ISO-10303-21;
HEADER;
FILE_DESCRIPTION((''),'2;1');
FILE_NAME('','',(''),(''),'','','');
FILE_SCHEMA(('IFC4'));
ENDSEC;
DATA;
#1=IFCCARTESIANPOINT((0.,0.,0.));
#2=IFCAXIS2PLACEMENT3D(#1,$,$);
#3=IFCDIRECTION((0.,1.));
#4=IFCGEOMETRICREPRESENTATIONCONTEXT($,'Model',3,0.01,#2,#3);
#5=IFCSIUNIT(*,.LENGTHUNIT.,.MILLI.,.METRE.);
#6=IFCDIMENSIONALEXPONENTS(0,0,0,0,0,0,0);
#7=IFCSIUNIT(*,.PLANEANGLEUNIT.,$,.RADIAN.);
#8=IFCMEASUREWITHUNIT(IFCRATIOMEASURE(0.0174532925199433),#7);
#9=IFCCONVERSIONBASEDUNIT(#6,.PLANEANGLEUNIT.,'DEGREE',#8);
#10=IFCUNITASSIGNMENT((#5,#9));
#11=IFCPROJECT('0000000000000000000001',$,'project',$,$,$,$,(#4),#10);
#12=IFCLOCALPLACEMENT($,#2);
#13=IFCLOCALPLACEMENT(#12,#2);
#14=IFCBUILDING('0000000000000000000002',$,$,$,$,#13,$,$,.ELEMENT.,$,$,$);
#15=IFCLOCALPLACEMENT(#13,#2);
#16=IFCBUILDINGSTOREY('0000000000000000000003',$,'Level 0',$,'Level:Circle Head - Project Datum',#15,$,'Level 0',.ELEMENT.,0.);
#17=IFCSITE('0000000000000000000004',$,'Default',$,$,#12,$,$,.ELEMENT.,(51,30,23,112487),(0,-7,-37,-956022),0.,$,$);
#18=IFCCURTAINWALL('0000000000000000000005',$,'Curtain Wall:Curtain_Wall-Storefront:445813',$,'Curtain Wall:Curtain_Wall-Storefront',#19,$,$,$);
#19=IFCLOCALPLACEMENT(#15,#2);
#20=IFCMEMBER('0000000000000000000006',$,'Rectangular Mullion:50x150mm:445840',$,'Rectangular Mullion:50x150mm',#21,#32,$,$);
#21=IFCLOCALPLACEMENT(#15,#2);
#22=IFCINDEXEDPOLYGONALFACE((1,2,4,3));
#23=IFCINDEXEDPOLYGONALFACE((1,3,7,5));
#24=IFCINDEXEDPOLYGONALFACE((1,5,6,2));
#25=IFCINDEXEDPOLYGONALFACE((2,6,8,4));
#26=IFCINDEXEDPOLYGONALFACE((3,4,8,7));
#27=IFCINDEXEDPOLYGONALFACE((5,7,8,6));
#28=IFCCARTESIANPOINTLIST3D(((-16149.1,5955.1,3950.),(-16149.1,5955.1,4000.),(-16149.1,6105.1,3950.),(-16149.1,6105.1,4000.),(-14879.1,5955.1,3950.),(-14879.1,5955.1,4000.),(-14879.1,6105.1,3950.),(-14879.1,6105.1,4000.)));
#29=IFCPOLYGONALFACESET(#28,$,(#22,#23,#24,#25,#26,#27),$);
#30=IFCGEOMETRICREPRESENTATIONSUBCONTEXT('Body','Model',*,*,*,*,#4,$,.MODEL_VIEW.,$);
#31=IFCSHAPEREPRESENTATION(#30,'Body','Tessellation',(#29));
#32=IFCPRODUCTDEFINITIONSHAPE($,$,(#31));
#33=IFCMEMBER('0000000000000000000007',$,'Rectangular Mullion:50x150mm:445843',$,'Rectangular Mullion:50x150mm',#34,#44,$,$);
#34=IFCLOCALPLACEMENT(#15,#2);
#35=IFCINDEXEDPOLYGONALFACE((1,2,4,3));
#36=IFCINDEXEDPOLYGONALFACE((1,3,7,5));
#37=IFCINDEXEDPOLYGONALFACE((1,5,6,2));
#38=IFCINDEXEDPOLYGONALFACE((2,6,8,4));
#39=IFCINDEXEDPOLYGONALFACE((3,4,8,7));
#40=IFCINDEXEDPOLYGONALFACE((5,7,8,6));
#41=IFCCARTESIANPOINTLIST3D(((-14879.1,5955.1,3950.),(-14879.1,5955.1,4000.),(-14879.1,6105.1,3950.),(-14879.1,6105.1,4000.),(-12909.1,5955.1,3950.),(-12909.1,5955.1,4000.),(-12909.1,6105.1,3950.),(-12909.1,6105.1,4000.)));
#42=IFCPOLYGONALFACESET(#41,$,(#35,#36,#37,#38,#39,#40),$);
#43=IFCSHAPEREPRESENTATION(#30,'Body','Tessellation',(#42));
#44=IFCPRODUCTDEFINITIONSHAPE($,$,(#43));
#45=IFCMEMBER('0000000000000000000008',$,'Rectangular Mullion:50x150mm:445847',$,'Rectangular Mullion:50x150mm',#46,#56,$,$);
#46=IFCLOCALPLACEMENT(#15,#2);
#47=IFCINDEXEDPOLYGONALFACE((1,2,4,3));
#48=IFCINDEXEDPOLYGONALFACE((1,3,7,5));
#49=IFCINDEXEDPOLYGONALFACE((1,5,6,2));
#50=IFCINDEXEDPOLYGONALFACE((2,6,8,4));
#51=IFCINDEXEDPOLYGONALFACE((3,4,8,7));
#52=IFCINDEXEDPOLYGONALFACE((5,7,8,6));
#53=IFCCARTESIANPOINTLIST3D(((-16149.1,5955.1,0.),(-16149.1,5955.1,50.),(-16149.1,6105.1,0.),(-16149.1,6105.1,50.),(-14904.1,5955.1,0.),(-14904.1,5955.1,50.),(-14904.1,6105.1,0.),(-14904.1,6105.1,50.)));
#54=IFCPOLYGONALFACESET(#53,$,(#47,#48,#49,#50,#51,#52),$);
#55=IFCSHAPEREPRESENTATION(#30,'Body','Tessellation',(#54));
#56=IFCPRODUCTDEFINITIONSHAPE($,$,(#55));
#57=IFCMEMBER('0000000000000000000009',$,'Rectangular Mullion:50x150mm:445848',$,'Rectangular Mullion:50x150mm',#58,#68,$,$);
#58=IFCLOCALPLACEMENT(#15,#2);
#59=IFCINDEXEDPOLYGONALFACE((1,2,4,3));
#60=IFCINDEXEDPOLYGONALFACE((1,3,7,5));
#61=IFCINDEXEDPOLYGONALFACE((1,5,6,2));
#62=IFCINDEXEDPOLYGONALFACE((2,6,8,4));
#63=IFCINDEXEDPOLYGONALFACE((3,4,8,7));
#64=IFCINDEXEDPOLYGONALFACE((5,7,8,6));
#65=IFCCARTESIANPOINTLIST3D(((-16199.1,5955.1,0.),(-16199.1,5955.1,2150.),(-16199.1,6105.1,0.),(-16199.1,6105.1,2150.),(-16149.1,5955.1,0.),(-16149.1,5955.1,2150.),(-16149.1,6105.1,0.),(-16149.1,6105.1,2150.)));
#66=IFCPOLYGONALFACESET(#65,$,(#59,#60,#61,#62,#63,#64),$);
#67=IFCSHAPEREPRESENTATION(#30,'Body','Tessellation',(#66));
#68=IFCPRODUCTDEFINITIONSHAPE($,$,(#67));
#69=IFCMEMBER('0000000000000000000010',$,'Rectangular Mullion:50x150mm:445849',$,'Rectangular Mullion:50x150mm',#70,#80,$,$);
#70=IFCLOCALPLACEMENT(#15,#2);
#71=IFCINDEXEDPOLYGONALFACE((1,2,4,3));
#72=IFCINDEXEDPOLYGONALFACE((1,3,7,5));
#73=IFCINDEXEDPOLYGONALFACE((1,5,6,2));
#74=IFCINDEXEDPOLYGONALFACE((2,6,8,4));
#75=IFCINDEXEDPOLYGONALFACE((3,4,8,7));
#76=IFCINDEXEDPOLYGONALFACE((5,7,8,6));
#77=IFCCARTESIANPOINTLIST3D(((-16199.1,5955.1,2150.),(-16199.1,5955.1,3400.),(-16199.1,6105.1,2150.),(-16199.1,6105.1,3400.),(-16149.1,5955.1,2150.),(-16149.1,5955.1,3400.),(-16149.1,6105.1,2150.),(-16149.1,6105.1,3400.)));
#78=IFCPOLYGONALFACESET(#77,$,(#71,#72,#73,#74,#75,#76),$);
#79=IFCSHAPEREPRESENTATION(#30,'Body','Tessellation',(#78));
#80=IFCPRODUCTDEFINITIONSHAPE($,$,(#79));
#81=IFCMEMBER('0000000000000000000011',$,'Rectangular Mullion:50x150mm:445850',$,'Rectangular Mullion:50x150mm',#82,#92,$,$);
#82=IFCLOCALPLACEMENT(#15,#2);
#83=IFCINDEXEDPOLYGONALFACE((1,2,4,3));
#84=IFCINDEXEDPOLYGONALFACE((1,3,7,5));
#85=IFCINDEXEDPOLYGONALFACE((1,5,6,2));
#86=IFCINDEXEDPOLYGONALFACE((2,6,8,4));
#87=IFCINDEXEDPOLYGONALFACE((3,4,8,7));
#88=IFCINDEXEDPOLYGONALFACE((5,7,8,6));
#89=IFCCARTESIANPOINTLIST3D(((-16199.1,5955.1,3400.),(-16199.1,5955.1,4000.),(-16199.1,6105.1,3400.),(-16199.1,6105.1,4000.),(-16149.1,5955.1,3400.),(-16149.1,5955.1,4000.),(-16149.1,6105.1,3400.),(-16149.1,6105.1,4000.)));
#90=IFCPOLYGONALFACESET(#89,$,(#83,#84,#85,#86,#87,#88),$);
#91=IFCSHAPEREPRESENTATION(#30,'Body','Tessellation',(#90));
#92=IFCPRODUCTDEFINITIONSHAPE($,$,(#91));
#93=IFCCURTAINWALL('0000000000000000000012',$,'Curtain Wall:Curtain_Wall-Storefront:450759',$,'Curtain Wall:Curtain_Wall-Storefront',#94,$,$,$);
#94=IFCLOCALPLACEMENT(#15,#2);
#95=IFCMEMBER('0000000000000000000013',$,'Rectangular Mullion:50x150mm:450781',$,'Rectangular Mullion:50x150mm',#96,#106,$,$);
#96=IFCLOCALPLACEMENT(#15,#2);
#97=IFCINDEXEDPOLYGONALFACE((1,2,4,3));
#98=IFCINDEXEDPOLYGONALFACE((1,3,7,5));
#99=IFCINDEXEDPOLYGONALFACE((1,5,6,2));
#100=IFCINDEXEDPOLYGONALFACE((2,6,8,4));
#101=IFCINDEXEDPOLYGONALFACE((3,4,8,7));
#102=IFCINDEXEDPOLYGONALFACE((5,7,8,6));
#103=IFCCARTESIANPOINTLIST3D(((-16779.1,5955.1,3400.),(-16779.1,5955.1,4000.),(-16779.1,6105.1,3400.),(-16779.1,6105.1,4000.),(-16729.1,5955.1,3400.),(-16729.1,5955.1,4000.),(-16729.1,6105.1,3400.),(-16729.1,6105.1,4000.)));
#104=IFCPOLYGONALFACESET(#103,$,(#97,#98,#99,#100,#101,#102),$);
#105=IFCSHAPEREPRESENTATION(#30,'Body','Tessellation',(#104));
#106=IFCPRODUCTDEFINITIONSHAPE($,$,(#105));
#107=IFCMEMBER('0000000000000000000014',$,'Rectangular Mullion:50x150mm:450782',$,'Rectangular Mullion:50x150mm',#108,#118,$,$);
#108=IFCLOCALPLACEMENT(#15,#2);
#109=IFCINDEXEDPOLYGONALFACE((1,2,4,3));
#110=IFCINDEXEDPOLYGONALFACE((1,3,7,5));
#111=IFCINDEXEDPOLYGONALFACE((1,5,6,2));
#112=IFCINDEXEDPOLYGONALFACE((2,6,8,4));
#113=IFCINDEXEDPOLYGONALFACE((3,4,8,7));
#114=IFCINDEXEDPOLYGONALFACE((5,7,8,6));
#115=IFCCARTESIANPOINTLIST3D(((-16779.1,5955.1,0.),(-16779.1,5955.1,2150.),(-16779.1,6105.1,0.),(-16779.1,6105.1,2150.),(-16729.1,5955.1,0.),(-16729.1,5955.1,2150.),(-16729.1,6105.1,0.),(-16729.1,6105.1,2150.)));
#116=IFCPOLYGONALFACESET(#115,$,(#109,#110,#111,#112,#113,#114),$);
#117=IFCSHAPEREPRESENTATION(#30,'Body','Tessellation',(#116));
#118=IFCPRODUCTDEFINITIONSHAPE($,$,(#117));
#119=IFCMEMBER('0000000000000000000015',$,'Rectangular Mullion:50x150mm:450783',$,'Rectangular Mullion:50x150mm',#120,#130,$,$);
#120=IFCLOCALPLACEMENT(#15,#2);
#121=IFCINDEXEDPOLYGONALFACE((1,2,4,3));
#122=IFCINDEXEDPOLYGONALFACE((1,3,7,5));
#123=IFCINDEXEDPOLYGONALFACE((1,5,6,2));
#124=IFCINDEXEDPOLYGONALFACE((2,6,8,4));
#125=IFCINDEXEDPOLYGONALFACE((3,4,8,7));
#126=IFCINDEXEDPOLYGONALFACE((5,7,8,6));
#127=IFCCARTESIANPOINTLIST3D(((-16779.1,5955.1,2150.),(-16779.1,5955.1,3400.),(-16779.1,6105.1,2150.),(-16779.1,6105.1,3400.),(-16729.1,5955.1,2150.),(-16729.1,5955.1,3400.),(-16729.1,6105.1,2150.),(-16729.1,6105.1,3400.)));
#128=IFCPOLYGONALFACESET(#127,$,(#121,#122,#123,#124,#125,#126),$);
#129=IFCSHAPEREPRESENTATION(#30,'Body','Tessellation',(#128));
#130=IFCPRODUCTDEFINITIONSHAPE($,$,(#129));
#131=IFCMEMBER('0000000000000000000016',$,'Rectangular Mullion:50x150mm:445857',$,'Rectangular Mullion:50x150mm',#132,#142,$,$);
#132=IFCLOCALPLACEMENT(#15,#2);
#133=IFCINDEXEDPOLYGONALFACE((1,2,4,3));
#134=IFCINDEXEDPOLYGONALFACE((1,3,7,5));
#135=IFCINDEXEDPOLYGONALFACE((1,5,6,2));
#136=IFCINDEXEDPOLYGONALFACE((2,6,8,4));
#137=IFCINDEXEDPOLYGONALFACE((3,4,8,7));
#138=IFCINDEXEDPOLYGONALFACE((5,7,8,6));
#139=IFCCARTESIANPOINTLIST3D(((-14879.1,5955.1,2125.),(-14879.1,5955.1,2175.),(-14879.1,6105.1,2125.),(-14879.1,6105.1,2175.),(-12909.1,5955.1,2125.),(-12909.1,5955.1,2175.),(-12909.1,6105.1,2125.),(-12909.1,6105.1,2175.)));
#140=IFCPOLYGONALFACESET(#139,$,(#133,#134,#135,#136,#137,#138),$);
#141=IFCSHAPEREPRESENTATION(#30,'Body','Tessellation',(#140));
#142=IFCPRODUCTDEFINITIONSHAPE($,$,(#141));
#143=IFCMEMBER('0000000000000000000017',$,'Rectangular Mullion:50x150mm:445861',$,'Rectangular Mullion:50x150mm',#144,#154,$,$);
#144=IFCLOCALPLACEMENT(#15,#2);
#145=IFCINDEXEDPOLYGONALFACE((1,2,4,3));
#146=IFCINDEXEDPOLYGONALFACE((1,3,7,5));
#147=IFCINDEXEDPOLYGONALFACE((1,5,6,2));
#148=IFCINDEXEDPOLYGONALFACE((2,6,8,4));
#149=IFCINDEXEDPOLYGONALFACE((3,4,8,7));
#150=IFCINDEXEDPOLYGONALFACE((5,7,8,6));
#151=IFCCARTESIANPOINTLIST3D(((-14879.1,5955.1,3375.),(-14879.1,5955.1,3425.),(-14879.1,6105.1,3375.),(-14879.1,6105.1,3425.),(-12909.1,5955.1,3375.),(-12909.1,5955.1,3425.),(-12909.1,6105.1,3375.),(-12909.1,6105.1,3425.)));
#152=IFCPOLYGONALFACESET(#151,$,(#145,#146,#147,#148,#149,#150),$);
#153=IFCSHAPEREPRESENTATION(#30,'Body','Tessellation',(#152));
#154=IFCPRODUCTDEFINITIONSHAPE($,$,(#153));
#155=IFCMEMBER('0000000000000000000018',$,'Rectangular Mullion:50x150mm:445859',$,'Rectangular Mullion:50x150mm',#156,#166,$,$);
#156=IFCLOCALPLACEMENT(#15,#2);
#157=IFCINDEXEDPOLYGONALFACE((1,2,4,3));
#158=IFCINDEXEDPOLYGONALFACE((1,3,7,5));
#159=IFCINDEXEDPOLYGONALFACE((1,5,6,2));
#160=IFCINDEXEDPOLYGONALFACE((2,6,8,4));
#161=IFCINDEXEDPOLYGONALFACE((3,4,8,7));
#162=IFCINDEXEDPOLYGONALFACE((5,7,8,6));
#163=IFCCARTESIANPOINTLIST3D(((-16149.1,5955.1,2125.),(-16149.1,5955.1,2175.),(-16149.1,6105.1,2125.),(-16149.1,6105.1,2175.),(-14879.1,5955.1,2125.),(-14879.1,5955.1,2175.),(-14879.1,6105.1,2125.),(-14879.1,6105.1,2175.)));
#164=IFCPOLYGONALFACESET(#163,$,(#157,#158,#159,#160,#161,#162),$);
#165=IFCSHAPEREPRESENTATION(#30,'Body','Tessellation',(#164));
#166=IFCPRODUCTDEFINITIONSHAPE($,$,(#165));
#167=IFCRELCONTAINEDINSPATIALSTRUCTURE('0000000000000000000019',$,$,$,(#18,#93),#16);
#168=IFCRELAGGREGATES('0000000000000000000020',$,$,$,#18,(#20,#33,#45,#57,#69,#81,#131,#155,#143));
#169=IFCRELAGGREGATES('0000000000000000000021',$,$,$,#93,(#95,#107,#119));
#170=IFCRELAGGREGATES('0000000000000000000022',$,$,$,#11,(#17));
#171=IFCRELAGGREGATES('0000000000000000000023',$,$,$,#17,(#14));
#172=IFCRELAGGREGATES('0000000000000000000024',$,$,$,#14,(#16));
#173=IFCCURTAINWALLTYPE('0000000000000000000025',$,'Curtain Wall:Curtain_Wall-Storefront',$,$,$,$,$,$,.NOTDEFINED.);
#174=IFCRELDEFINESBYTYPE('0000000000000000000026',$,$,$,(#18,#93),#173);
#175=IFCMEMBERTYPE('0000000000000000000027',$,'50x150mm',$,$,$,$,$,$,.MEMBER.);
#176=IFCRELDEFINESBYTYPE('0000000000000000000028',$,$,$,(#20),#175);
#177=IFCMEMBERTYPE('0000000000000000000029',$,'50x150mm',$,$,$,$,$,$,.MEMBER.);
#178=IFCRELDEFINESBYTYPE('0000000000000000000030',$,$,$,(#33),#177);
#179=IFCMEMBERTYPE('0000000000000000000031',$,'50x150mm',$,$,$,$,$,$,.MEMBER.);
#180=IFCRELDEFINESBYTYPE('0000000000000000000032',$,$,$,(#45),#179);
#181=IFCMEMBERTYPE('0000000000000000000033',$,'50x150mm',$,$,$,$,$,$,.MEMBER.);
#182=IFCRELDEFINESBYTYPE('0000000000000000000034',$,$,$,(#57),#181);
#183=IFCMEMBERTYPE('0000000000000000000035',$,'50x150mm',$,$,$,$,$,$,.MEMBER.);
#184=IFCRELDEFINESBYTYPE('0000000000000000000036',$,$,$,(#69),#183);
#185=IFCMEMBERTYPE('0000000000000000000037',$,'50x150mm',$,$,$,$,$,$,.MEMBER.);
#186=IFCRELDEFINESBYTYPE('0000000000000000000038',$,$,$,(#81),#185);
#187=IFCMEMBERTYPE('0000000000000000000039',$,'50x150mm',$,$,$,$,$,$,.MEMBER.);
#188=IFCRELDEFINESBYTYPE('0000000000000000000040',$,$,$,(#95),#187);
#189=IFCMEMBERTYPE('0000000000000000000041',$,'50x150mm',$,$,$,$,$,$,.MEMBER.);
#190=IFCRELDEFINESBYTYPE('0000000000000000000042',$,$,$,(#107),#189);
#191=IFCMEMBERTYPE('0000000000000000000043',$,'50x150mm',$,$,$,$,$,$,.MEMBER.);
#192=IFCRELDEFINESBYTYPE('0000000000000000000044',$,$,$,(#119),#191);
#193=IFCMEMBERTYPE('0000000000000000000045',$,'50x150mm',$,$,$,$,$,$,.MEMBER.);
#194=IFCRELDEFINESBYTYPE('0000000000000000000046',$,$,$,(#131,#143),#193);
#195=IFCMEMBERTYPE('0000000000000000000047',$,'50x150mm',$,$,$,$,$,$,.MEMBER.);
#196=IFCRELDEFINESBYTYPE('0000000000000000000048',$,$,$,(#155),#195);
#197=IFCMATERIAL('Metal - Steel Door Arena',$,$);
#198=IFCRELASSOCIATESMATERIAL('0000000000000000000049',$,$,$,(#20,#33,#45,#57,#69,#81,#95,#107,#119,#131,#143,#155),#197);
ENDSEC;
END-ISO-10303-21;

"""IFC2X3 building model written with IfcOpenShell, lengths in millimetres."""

from ifc_helpers import new_model, entity, si_unit, converted_unit, direction, frame, origin, origin_2d_with_axis, place, context, subcontext, project, spatial, rectangle, extrude, source, transform, mapped, material, type_object, type_shapes, element, aggregate, save


model = new_model("IFC2X3")

# Units and contexts
model_context = context("Model", 3, precision=0.01, world=origin(), true_north=direction((0.0, 1.0)))
body_context = subcontext(model_context, "Body", "Model", "MODEL_VIEW")
ifc_project = project(units=[si_unit("LENGTHUNIT", "METRE", prefix="MILLI"), converted_unit("PLANEANGLEUNIT", "DEGREE", entity("IfcRatioMeasure", 0.0174532925199433), si_unit("PLANEANGLEUNIT", "RADIAN"), dimensions=[0, 0, 0, 0, 0, 0, 0])], contexts=[model_context])

# Site, building, storey
site_placement = place(None, origin())
site = spatial("IfcSite", under=ifc_project, at=site_placement, Name="Default", CompositionType="ELEMENT", RefLatitude=(51, 30, 23, 112487), RefLongitude=(0, -7, -37, -956022), RefElevation=0.0)
building_placement = place(site_placement, origin())
building = spatial("IfcBuilding", under=site, at=building_placement, CompositionType="ELEMENT")
storey_placement = place(building_placement, origin())
storey = spatial("IfcBuildingStorey", under=building, at=storey_placement, Name="Level 0", ObjectType="Level:Circle Head - Project Datum", LongName="Level 0", CompositionType="ELEMENT", Elevation=0.0)

# Curtain walls, members
curtain_wall_type = type_object("IfcCurtainWallType", Name="Curtain Wall:Curtain_Wall-Storefront", PredefinedType="NOTDEFINED")
curtain_wall_1_placement = place(storey_placement, origin())
curtain_wall_1 = element("IfcCurtainWall", 1, at=curtain_wall_1_placement, inside=storey, type_object=curtain_wall_type, Name="Curtain Wall:Curtain_Wall-Storefront:445813", ObjectType="Curtain Wall:Curtain_Wall-Storefront")
ifc_material_1 = material(Name="Metal - Steel Door Arena")
member_type_1 = type_object("IfcMemberType", Name="50x150mm", PredefinedType="MEMBER")
shared_shape_1 = source(origin(), body_context, "Body", "SweptSolid", [
    extrude(rectangle(XDim=150.0, YDim=50.0, at=origin_2d_with_axis()), frame((-25.0, 0.0, -1270.0), z_axis=(0.0, 0.0, 1.0), x_axis=(0.0, -1.0, 0.0)), (0.0, 0.0, 1.0), 1270.0),
])
type_shapes(member_type_1, [shared_shape_1])
member_1_placement = place(storey_placement, frame((-16149.1, 6030.1, 4000.0), z_axis=(-1.0, 0.0, 0.0), x_axis=(0.0, 0.0, 1.0)))
member_1 = element("IfcMember", 2, at=member_1_placement, type_object=member_type_1, material=ifc_material_1, Name="Rectangular Mullion:50x150mm:445840", ObjectType="Rectangular Mullion:50x150mm", context=body_context, shape_type="MappedRepresentation", body=[
    mapped(shared_shape_1, transform((0.0, 0.0, 0.0), scale=1.0)),
])
member_type_2 = type_object("IfcMemberType", Name="50x150mm", PredefinedType="MEMBER")
shared_shape_2 = source(origin(), body_context, "Body", "SweptSolid", [
    extrude(rectangle(XDim=150.0, YDim=50.0, at=origin_2d_with_axis()), frame((-25.0, 0.0, -1970.0), z_axis=(0.0, 0.0, 1.0), x_axis=(0.0, -1.0, 0.0)), (0.0, 0.0, 1.0), 1970.0),
])
type_shapes(member_type_2, [shared_shape_2])
member_2_placement = place(storey_placement, frame((-14879.1, 6030.1, 4000.0), z_axis=(-1.0, 0.0, 0.0), x_axis=(0.0, 0.0, 1.0)))
member_2 = element("IfcMember", 3, at=member_2_placement, type_object=member_type_2, material=ifc_material_1, Name="Rectangular Mullion:50x150mm:445843", ObjectType="Rectangular Mullion:50x150mm", context=body_context, shape_type="MappedRepresentation", body=[
    mapped(shared_shape_2, transform((0.0, 0.0, 0.0), scale=1.0)),
])
member_type_3 = type_object("IfcMemberType", Name="50x150mm", PredefinedType="MEMBER")
shared_shape_3 = source(origin(), body_context, "Body", "SweptSolid", [
    extrude(rectangle(XDim=150.0, YDim=50.0, at=origin_2d_with_axis()), frame((-25.0, 0.0, -1245.0), z_axis=(0.0, 0.0, 1.0), x_axis=(0.0, -1.0, 0.0)), (0.0, 0.0, 1.0), 1245.0),
])
type_shapes(member_type_3, [shared_shape_3])
member_3_placement = place(storey_placement, frame((-14904.1, 6030.1, 0.0), z_axis=(1.0, 0.0, 0.0), x_axis=(0.0, 0.0, -1.0)))
member_3 = element("IfcMember", 4, at=member_3_placement, type_object=member_type_3, material=ifc_material_1, Name="Rectangular Mullion:50x150mm:445847", ObjectType="Rectangular Mullion:50x150mm", context=body_context, shape_type="MappedRepresentation", body=[
    mapped(shared_shape_3, transform((0.0, 0.0, 0.0), scale=1.0)),
])
member_type_4 = type_object("IfcMemberType", Name="50x150mm", PredefinedType="MEMBER")
shared_shape_4 = source(origin(), body_context, "Body", "SweptSolid", [
    extrude(rectangle(XDim=150.0, YDim=50.0, at=origin_2d_with_axis()), frame((-25.0, 0.0, -2150.0), z_axis=(0.0, 0.0, 1.0), x_axis=(0.0, -1.0, 0.0)), (0.0, 0.0, 1.0), 2150.0),
])
type_shapes(member_type_4, [shared_shape_4])
member_4_placement = place(storey_placement, frame((-16199.1, 6030.1, 0.0), z_axis=(0.0, 0.0, -1.0), x_axis=(-1.0, 0.0, 0.0)))
member_4 = element("IfcMember", 5, at=member_4_placement, type_object=member_type_4, material=ifc_material_1, Name="Rectangular Mullion:50x150mm:445848", ObjectType="Rectangular Mullion:50x150mm", context=body_context, shape_type="MappedRepresentation", body=[
    mapped(shared_shape_4, transform((0.0, 0.0, 0.0), scale=1.0)),
])
member_type_5 = type_object("IfcMemberType", Name="50x150mm", PredefinedType="MEMBER")
shared_shape_5 = source(origin(), body_context, "Body", "SweptSolid", [
    extrude(rectangle(XDim=150.0, YDim=50.0, at=origin_2d_with_axis()), frame((-25.0, 0.0, -1250.0), z_axis=(0.0, 0.0, 1.0), x_axis=(0.0, -1.0, 0.0)), (0.0, 0.0, 1.0), 1250.0),
])
type_shapes(member_type_5, [shared_shape_5])
member_5_placement = place(storey_placement, frame((-16199.1, 6030.1, 2150.0), z_axis=(0.0, 0.0, -1.0), x_axis=(-1.0, 0.0, 0.0)))
member_5 = element("IfcMember", 6, at=member_5_placement, type_object=member_type_5, material=ifc_material_1, Name="Rectangular Mullion:50x150mm:445849", ObjectType="Rectangular Mullion:50x150mm", context=body_context, shape_type="MappedRepresentation", body=[
    mapped(shared_shape_5, transform((0.0, 0.0, 0.0), scale=1.0)),
])
member_type_6 = type_object("IfcMemberType", Name="50x150mm", PredefinedType="MEMBER")
shared_shape_6 = source(origin(), body_context, "Body", "SweptSolid", [
    extrude(rectangle(XDim=150.0, YDim=50.0, at=origin_2d_with_axis()), frame((-25.0, 0.0, -600.0), z_axis=(0.0, 0.0, 1.0), x_axis=(0.0, -1.0, 0.0)), (0.0, 0.0, 1.0), 600.0),
])
type_shapes(member_type_6, [shared_shape_6])
member_6_placement = place(storey_placement, frame((-16199.1, 6030.1, 3400.0), z_axis=(0.0, 0.0, -1.0), x_axis=(-1.0, 0.0, 0.0)))
member_6 = element("IfcMember", 7, at=member_6_placement, type_object=member_type_6, material=ifc_material_1, Name="Rectangular Mullion:50x150mm:445850", ObjectType="Rectangular Mullion:50x150mm", context=body_context, shape_type="MappedRepresentation", body=[
    mapped(shared_shape_6, transform((0.0, 0.0, 0.0), scale=1.0)),
])
curtain_wall_2_placement = place(storey_placement, origin())
curtain_wall_2 = element("IfcCurtainWall", 8, at=curtain_wall_2_placement, inside=storey, type_object=curtain_wall_type, Name="Curtain Wall:Curtain_Wall-Storefront:450759", ObjectType="Curtain Wall:Curtain_Wall-Storefront")
member_type_7 = type_object("IfcMemberType", Name="50x150mm", PredefinedType="MEMBER")
shared_shape_7 = source(origin(), body_context, "Body", "SweptSolid", [
    extrude(rectangle(XDim=150.0, YDim=50.0, at=origin_2d_with_axis()), frame((-25.0, 0.0, -600.0), z_axis=(0.0, 0.0, 1.0), x_axis=(0.0, -1.0, 0.0)), (0.0, 0.0, 1.0), 600.0),
])
type_shapes(member_type_7, [shared_shape_7])
member_7_placement = place(storey_placement, frame((-16729.1, 6030.1, 4000.0)))
member_7 = element("IfcMember", 9, at=member_7_placement, type_object=member_type_7, material=ifc_material_1, Name="Rectangular Mullion:50x150mm:450781", ObjectType="Rectangular Mullion:50x150mm", context=body_context, shape_type="MappedRepresentation", body=[
    mapped(shared_shape_7, transform((0.0, 0.0, 0.0), scale=1.0)),
])
member_type_8 = type_object("IfcMemberType", Name="50x150mm", PredefinedType="MEMBER")
shared_shape_8 = source(origin(), body_context, "Body", "SweptSolid", [
    extrude(rectangle(XDim=150.0, YDim=50.0, at=origin_2d_with_axis()), frame((-25.0, 0.0, -2150.0), z_axis=(0.0, 0.0, 1.0), x_axis=(0.0, -1.0, 0.0)), (0.0, 0.0, 1.0), 2150.0),
])
type_shapes(member_type_8, [shared_shape_8])
member_8_placement = place(storey_placement, frame((-16729.1, 6030.1, 2150.0)))
member_8 = element("IfcMember", 10, at=member_8_placement, type_object=member_type_8, material=ifc_material_1, Name="Rectangular Mullion:50x150mm:450782", ObjectType="Rectangular Mullion:50x150mm", context=body_context, shape_type="MappedRepresentation", body=[
    mapped(shared_shape_8, transform((0.0, 0.0, 0.0), scale=1.0)),
])
member_type_9 = type_object("IfcMemberType", Name="50x150mm", PredefinedType="MEMBER")
shared_shape_9 = source(origin(), body_context, "Body", "SweptSolid", [
    extrude(rectangle(XDim=150.0, YDim=50.0, at=origin_2d_with_axis()), frame((-25.0, 0.0, -1250.0), z_axis=(0.0, 0.0, 1.0), x_axis=(0.0, -1.0, 0.0)), (0.0, 0.0, 1.0), 1250.0),
])
type_shapes(member_type_9, [shared_shape_9])
member_9_placement = place(storey_placement, frame((-16729.1, 6030.1, 3400.0)))
member_9 = element("IfcMember", 11, at=member_9_placement, type_object=member_type_9, material=ifc_material_1, Name="Rectangular Mullion:50x150mm:450783", ObjectType="Rectangular Mullion:50x150mm", context=body_context, shape_type="MappedRepresentation", body=[
    mapped(shared_shape_9, transform((0.0, 0.0, 0.0), scale=1.0)),
])

# Members
member_type_10 = type_object("IfcMemberType", Name="50x150mm", PredefinedType="MEMBER")
shared_shape_10 = source(origin(), body_context, "Body", "SweptSolid", [
    extrude(rectangle(XDim=150.0, YDim=50.0, at=origin_2d_with_axis()), frame((0.0, 0.0, -1970.0), z_axis=(0.0, 0.0, 1.0), x_axis=(0.0, -1.0, 0.0)), (0.0, 0.0, 1.0), 1970.0),
])
type_shapes(member_type_10, [shared_shape_10])
member_10_placement = place(storey_placement, frame((-14879.1, 6030.1, 2150.0), z_axis=(-1.0, 0.0, 0.0), x_axis=(0.0, 0.0, 1.0)))
member_10 = element("IfcMember", 12, at=member_10_placement, type_object=member_type_10, material=ifc_material_1, Name="Rectangular Mullion:50x150mm:445857", ObjectType="Rectangular Mullion:50x150mm", context=body_context, shape_type="MappedRepresentation", body=[
    mapped(shared_shape_10, transform((0.0, 0.0, 0.0), scale=1.0)),
])
member_11_placement = place(storey_placement, frame((-14879.1, 6030.1, 3400.0), z_axis=(-1.0, 0.0, 0.0), x_axis=(0.0, 0.0, 1.0)))
member_11 = element("IfcMember", 13, at=member_11_placement, type_object=member_type_10, material=ifc_material_1, Name="Rectangular Mullion:50x150mm:445861", ObjectType="Rectangular Mullion:50x150mm", context=body_context, shape_type="MappedRepresentation", body=[
    mapped(shared_shape_10, transform((0.0, 0.0, 0.0), scale=1.0)),
])
member_type_11 = type_object("IfcMemberType", Name="50x150mm", PredefinedType="MEMBER")
shared_shape_11 = source(origin(), body_context, "Body", "SweptSolid", [
    extrude(rectangle(XDim=150.0, YDim=50.0, at=origin_2d_with_axis()), frame((0.0, 0.0, -1270.0), z_axis=(0.0, 0.0, 1.0), x_axis=(0.0, -1.0, 0.0)), (0.0, 0.0, 1.0), 1270.0),
])
type_shapes(member_type_11, [shared_shape_11])
member_12_placement = place(storey_placement, frame((-16149.1, 6030.1, 2150.0), z_axis=(-1.0, 0.0, 0.0), x_axis=(0.0, 0.0, 1.0)))
member_12 = element("IfcMember", 14, at=member_12_placement, type_object=member_type_11, material=ifc_material_1, Name="Rectangular Mullion:50x150mm:445859", ObjectType="Rectangular Mullion:50x150mm", context=body_context, shape_type="MappedRepresentation", body=[
    mapped(shared_shape_11, transform((0.0, 0.0, 0.0), scale=1.0)),
])

aggregate(curtain_wall_1, [member_1, member_2, member_3, member_4, member_5, member_6, member_10, member_12, member_11])
aggregate(curtain_wall_2, [member_7, member_8, member_9])

save(model, "model.ifc")
